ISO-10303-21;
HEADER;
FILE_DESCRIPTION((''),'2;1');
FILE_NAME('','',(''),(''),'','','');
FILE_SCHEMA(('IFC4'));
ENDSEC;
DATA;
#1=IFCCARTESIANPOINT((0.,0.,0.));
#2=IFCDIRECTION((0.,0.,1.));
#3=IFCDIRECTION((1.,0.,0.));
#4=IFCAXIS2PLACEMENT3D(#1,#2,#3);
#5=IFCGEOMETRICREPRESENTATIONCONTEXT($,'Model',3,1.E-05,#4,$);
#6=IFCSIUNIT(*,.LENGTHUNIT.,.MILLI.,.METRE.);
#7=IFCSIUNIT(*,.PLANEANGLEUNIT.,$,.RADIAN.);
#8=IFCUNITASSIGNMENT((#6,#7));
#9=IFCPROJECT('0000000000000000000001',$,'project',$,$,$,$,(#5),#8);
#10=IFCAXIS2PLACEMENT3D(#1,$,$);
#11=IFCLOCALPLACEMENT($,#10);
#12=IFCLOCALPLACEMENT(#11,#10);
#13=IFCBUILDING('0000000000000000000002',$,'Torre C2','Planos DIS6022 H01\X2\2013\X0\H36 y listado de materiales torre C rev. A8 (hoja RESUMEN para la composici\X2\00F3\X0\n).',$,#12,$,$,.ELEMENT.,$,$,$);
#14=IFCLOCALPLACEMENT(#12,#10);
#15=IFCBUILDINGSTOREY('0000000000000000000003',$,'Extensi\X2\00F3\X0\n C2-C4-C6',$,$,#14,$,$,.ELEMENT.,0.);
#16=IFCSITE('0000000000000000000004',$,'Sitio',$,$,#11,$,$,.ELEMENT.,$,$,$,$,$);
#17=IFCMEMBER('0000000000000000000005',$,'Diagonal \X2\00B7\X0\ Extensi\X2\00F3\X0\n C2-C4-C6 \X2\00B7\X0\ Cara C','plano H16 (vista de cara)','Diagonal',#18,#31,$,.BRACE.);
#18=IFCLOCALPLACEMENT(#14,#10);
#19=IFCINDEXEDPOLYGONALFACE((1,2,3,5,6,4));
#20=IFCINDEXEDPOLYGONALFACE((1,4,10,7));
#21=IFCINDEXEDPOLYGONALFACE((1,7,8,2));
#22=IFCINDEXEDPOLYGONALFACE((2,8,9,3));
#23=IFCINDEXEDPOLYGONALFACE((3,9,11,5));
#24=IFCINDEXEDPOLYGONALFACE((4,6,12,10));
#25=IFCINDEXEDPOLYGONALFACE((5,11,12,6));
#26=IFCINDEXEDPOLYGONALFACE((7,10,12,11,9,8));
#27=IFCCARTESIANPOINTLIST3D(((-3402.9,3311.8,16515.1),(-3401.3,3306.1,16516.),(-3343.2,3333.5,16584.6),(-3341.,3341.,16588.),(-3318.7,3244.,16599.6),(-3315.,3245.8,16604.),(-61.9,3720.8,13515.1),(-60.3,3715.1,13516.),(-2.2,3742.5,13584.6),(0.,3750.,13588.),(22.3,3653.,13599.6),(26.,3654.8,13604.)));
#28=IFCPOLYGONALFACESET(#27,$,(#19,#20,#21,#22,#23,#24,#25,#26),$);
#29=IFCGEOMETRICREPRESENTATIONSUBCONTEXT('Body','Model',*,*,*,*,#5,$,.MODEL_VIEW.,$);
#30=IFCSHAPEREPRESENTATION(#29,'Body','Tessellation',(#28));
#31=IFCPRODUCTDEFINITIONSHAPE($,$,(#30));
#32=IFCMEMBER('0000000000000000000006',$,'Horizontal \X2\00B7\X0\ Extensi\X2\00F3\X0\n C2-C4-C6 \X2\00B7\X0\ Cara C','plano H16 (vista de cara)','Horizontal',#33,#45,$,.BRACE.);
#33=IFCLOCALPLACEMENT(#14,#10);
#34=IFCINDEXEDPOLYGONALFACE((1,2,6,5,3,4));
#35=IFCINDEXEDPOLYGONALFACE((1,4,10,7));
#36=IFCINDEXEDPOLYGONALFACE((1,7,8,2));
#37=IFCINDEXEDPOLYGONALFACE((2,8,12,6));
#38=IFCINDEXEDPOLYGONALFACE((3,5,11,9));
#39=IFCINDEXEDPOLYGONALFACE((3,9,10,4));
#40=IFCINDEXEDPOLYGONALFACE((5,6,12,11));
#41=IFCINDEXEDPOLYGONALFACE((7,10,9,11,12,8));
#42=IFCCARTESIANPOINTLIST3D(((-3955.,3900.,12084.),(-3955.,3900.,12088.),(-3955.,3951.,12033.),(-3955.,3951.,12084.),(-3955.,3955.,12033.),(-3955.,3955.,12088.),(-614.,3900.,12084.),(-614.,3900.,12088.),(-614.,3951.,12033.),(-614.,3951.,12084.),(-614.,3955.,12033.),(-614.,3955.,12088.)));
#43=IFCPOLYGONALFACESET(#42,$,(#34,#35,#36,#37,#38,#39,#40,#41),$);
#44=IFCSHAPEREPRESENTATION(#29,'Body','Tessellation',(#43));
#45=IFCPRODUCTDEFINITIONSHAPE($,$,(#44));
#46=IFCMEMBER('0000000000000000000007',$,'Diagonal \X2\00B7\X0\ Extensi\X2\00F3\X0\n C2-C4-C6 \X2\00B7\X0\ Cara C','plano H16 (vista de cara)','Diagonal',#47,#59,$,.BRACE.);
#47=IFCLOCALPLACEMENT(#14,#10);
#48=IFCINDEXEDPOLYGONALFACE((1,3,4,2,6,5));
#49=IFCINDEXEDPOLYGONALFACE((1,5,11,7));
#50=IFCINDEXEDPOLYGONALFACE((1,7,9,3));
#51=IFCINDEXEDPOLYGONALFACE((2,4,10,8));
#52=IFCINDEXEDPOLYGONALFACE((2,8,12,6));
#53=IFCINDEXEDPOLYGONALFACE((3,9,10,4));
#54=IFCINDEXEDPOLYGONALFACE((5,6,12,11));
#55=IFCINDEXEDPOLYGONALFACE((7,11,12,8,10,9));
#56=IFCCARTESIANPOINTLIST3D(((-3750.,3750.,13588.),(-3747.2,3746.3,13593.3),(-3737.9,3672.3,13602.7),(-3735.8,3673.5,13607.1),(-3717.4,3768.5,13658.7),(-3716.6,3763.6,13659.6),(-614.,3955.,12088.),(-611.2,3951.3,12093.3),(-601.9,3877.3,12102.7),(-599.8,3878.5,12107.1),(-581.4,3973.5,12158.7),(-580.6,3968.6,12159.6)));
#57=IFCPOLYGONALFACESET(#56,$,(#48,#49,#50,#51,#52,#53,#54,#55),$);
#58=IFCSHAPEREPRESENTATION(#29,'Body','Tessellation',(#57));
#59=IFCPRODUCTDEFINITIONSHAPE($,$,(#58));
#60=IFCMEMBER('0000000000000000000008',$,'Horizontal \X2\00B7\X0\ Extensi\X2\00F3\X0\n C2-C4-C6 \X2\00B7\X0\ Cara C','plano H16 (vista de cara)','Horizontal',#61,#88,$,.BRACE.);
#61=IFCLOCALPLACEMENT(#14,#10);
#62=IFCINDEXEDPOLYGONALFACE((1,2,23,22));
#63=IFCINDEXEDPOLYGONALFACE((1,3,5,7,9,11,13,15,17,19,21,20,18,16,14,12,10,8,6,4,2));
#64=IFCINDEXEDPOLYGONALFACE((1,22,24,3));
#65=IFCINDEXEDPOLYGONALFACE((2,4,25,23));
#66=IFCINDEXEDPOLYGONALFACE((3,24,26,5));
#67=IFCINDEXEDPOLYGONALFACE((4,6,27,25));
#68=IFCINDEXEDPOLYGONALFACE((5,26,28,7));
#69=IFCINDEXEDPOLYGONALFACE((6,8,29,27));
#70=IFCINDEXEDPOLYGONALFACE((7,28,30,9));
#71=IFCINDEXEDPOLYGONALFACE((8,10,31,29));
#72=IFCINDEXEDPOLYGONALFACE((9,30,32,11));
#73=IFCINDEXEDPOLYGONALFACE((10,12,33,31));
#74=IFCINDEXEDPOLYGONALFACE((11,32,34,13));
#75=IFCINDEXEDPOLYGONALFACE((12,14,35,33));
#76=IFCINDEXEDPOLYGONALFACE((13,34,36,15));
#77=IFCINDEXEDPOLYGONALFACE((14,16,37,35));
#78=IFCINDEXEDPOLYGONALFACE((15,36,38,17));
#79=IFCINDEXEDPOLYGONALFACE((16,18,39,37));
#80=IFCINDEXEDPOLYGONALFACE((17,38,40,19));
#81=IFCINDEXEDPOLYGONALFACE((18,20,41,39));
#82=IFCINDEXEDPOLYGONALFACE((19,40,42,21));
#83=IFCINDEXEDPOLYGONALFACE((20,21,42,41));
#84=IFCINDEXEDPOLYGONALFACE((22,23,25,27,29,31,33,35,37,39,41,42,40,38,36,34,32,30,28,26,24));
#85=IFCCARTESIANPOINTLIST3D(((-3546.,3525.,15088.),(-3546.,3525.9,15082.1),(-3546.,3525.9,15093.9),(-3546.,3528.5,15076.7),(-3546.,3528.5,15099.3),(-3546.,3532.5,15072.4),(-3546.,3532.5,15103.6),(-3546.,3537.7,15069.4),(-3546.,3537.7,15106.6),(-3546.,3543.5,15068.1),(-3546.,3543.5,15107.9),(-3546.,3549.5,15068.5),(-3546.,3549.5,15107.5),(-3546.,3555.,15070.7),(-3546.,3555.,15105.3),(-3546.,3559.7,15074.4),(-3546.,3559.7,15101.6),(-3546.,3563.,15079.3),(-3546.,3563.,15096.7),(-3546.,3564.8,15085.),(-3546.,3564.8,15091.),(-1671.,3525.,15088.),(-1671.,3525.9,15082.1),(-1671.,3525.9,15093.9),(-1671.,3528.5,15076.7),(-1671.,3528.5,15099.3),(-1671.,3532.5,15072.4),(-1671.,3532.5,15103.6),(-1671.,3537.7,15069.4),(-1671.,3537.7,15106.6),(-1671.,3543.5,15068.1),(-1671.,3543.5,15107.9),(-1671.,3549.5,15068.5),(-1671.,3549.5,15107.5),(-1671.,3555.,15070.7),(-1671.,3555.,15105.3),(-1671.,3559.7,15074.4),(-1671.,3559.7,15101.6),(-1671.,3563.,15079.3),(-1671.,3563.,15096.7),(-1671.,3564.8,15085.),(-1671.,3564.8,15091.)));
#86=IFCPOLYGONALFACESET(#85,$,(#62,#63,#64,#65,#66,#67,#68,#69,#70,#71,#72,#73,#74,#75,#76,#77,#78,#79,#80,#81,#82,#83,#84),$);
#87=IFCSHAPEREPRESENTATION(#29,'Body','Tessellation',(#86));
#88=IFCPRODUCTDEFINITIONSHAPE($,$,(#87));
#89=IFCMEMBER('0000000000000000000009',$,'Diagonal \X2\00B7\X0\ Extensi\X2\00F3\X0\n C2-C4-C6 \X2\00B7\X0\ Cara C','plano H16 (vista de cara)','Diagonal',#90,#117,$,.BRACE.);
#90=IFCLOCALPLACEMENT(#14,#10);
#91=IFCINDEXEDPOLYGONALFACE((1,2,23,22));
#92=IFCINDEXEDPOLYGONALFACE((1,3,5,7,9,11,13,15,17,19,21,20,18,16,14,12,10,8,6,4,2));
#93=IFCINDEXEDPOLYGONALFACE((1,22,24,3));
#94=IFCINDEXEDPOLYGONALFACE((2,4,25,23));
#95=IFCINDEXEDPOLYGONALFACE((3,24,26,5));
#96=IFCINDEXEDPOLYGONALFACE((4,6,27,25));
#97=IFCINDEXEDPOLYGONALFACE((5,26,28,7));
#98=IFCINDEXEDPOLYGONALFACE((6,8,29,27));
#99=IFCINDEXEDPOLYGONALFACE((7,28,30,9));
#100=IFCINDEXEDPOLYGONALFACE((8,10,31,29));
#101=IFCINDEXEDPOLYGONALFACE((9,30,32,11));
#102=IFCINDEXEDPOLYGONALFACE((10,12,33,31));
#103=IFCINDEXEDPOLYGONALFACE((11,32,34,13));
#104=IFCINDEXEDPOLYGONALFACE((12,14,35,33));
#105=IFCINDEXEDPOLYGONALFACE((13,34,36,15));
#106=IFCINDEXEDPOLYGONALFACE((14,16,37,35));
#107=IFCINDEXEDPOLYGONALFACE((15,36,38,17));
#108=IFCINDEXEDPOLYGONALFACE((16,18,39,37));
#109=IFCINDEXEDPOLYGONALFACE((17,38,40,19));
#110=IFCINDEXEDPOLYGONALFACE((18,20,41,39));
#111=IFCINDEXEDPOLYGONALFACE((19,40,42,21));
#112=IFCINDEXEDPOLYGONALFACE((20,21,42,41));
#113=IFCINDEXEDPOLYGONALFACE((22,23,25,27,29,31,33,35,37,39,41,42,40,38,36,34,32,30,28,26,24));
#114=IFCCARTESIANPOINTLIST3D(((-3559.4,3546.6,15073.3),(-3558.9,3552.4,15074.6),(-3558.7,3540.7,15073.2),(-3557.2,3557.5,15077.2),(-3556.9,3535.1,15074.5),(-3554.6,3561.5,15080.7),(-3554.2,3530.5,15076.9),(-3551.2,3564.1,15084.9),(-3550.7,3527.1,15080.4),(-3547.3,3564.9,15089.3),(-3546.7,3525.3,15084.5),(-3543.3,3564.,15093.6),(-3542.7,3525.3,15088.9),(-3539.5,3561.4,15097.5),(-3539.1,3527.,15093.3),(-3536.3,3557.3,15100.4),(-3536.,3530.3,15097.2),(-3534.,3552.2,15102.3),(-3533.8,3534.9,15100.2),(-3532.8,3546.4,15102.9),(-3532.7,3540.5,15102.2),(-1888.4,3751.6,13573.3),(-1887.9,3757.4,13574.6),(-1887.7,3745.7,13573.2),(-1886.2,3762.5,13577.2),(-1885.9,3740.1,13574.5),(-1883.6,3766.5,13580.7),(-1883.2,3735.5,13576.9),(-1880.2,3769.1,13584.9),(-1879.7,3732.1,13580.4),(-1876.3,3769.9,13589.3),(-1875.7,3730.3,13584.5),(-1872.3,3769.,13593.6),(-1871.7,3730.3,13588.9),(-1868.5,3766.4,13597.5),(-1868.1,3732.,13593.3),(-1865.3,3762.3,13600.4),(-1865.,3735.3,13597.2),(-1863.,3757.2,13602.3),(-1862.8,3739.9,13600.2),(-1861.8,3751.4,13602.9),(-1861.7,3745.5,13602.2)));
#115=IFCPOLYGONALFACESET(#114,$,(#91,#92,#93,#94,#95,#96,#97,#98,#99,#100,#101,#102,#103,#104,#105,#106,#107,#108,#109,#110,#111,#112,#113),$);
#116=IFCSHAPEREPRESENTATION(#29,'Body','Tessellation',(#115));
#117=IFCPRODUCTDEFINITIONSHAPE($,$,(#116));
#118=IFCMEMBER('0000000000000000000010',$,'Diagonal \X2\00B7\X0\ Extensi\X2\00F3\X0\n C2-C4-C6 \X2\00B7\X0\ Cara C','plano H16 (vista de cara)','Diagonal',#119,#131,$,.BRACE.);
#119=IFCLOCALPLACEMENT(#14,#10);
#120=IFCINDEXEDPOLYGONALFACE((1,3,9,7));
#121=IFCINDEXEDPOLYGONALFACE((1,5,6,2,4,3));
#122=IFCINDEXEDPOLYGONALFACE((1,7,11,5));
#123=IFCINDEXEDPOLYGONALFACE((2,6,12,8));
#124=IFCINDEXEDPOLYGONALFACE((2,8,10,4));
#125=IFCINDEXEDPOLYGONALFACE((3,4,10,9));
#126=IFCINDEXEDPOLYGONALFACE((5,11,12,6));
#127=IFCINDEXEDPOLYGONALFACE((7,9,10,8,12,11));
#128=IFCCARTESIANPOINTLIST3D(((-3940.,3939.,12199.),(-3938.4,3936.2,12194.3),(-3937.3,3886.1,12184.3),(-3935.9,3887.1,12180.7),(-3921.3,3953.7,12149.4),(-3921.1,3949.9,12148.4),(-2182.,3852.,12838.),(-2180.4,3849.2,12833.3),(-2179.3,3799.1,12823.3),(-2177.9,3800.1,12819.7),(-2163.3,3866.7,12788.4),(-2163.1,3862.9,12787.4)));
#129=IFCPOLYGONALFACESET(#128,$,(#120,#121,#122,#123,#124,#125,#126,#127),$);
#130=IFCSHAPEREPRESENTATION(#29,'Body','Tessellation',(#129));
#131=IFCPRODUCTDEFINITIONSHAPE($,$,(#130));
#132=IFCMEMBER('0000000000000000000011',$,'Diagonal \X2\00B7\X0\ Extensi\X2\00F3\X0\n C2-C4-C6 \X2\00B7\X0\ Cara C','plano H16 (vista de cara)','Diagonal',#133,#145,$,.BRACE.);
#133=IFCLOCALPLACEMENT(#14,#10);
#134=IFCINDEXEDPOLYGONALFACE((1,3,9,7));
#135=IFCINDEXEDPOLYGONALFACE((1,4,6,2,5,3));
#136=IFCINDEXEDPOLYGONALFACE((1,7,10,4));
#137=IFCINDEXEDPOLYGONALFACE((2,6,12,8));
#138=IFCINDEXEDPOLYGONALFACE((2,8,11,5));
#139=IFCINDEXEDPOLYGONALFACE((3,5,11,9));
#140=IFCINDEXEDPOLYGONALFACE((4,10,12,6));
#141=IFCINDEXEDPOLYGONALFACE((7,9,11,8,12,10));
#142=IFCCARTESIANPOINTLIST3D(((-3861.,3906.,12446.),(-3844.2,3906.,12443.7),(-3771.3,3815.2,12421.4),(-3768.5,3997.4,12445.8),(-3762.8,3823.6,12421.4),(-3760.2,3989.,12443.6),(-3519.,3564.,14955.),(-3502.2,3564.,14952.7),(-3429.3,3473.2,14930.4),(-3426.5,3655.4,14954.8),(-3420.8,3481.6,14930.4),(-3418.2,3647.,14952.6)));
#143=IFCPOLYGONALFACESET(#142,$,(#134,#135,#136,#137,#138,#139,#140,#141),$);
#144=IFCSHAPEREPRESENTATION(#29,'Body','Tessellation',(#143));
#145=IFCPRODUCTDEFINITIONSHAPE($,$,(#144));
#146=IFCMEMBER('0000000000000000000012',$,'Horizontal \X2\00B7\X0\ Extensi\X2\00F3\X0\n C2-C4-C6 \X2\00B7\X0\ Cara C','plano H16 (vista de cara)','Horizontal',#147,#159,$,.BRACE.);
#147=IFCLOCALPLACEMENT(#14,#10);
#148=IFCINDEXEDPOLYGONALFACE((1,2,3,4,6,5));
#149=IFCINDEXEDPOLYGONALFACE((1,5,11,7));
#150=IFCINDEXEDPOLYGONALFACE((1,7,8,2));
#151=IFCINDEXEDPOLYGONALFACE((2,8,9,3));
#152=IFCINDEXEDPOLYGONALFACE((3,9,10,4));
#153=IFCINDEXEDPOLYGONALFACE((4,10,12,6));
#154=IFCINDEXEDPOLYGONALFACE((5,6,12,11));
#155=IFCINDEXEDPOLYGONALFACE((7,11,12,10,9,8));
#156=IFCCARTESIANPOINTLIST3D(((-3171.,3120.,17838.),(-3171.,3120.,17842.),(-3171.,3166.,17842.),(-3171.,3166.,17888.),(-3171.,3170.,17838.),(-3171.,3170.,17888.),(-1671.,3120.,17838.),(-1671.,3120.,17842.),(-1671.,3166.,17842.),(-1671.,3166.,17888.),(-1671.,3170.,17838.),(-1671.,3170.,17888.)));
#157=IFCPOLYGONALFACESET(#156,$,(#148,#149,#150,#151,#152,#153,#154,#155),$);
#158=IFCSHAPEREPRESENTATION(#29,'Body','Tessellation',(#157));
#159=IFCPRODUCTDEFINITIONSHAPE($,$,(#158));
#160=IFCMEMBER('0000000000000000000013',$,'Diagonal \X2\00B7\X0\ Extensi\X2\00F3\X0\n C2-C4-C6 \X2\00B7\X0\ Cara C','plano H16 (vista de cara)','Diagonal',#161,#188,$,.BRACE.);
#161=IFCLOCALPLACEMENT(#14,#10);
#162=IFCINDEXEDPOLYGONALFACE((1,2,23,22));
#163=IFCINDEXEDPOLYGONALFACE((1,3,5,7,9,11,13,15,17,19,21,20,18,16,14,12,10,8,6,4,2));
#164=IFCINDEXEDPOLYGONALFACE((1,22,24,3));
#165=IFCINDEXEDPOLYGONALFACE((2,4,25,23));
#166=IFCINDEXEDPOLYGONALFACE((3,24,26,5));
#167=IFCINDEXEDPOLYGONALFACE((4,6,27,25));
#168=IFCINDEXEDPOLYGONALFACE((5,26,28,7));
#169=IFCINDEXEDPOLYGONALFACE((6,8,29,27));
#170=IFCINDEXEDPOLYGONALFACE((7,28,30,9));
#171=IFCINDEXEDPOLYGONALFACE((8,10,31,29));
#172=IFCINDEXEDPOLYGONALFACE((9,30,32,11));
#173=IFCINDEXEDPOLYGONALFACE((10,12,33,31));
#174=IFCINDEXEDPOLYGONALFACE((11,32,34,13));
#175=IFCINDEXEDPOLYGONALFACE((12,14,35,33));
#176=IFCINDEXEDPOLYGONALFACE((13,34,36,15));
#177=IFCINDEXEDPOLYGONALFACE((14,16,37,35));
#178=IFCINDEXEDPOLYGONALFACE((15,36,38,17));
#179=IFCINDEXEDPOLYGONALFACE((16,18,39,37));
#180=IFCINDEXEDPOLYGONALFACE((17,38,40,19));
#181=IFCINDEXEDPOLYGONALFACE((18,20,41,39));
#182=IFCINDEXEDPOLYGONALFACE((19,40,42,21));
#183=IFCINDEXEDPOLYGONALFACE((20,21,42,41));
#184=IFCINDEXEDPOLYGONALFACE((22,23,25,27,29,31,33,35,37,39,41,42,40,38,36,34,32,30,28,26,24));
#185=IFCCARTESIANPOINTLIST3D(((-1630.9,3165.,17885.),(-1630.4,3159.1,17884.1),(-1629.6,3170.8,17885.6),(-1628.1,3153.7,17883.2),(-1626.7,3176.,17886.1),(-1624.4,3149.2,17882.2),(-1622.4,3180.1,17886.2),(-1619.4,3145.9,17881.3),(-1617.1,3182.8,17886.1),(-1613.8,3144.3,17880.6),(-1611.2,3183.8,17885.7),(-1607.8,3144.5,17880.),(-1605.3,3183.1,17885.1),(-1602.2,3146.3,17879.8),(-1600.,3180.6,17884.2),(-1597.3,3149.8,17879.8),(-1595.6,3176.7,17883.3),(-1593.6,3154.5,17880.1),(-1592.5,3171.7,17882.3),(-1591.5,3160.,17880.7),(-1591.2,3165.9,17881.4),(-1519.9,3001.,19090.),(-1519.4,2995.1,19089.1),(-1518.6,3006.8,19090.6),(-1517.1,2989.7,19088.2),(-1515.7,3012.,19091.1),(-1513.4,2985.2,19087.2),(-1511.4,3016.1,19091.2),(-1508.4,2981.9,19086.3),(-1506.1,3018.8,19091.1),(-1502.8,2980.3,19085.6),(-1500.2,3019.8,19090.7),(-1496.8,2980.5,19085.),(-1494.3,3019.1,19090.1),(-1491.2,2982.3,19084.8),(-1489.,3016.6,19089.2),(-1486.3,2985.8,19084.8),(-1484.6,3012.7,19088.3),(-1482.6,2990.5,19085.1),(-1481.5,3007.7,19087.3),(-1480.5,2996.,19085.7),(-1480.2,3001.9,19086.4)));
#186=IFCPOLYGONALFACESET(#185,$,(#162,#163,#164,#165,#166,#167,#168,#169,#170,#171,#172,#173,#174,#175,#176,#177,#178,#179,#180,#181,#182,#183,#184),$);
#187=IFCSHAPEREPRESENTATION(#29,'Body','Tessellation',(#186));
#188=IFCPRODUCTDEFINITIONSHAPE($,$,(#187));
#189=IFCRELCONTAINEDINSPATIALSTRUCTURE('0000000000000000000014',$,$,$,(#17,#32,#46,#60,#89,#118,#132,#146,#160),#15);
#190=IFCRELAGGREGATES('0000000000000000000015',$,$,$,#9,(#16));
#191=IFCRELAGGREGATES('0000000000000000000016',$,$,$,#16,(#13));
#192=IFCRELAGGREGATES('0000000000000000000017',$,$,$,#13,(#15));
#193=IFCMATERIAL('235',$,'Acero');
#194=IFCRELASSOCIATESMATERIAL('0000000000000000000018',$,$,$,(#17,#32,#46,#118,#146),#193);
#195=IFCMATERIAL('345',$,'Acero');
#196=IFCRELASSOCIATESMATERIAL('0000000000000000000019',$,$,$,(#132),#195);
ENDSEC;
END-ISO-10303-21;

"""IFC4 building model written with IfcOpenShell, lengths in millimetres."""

from ifc_helpers import new_model, si_unit, frame, frame_2d, origin, origin_with_axes, place, context, subcontext, project, spatial, circle, l_section, extrude, material, element, save


model = new_model("IFC4")

# Units and contexts
model_context = context("Model", 3, precision=1e-05, world=origin_with_axes())
body_context = subcontext(model_context, "Body", "Model", "MODEL_VIEW")
ifc_project = project(units=[si_unit("LENGTHUNIT", "METRE", prefix="MILLI"), si_unit("PLANEANGLEUNIT", "RADIAN")], contexts=[model_context])

# Site, building, storey
site_placement = place(None, origin())
site = spatial("IfcSite", under=ifc_project, at=site_placement, Name="Sitio", CompositionType="ELEMENT")
building_placement = place(site_placement, origin())
building = spatial("IfcBuilding", under=site, at=building_placement, Name="Torre C2", Description="Planos DIS6022 H01–H36 y listado de materiales torre C rev. A8 (hoja RESUMEN para la composición).", CompositionType="ELEMENT")
storey_placement = place(building_placement, origin())
storey = spatial("IfcBuildingStorey", under=building, at=storey_placement, Name="Extensión C2-C4-C6", CompositionType="ELEMENT", Elevation=0.0)

# Members
ifc_material_1 = material(Name="235", Category="Acero")
member_1_placement = place(storey_placement, frame((-3341.0, 3341.0, 16588.0), z_axis=(0.74099, 0.090711, -0.665361), x_axis=(0.260212, -0.952207, 0.159972)))
element("IfcMember", 1, at=member_1_placement, inside=storey, material=ifc_material_1, Name="Diagonal · Extensión C2-C4-C6 · Cara C", Description="plano H16 (vista de cara)", ObjectType="Diagonal", PredefinedType="BRACE", context=body_context, shape_type="SweptSolid", body=[
    extrude(l_section(Depth=100.0, Width=100.0, Thickness=6.0, at=frame_2d((50.0, 50.0))), None, (0.0, 0.0, 1.0), 4508.8),
])
member_2_placement = place(storey_placement, frame((-3955.0, 3955.0, 12088.0), z_axis=(1.0, 0.0, 0.0), x_axis=(0.0, -1.0, 0.0)))
element("IfcMember", 2, at=member_2_placement, inside=storey, material=ifc_material_1, Name="Horizontal · Extensión C2-C4-C6 · Cara C", Description="plano H16 (vista de cara)", ObjectType="Horizontal", PredefinedType="BRACE", context=body_context, shape_type="SweptSolid", body=[
    extrude(l_section(Depth=55.0, Width=55.0, Thickness=4.0, at=frame_2d((27.5, 27.5))), None, (0.0, 0.0, 1.0), 3341.0),
])
member_3_placement = place(storey_placement, frame((-614.0, 3955.0, 12088.0), z_axis=(-0.90055, -0.058869, 0.430748), x_axis=(0.151437, -0.971215, 0.183871)))
element("IfcMember", 3, at=member_3_placement, inside=storey, material=ifc_material_1, Name="Diagonal · Extensión C2-C4-C6 · Cara C", Description="plano H16 (vista de cara)", ObjectType="Diagonal", PredefinedType="BRACE", context=body_context, shape_type="SweptSolid", body=[
    extrude(l_section(Depth=80.0, Width=80.0, Thickness=5.0, at=frame_2d((40.0, 40.0))), None, (0.0, 0.0, 1.0), 3482.3),
])
member_4_placement = place(storey_placement, frame((-1671.0, 3545.0, 15088.0), z_axis=(-1.0, 0.0, 0.0), x_axis=(0.0, -1.0, 0.0)))
element("IfcMember", 4, at=member_4_placement, inside=storey, Name="Horizontal · Extensión C2-C4-C6 · Cara C", Description="plano H16 (vista de cara)", ObjectType="Horizontal", PredefinedType="BRACE", context=body_context, shape_type="SweptSolid", body=[
    extrude(circle(Radius=20.0), None, (0.0, 0.0, 1.0), 1875.0),
])
member_5_placement = place(storey_placement, frame((-3546.0, 3545.0, 15088.0), z_axis=(0.741075, 0.090916, -0.665238), x_axis=(0.347494, -0.899707, 0.264149)))
element("IfcMember", 5, at=member_5_placement, inside=storey, Name="Diagonal · Extensión C2-C4-C6 · Cara C", Description="plano H16 (vista de cara)", ObjectType="Diagonal", PredefinedType="BRACE", context=body_context, shape_type="SweptSolid", body=[
    extrude(circle(Radius=20.0), None, (0.0, 0.0, 1.0), 2254.8),
])
member_6_placement = place(storey_placement, frame((-3940.0, 3939.0, 12199.0), z_axis=(0.938825, -0.046461, 0.341245), x_axis=(0.049518, -0.962352, -0.267257)))
element("IfcMember", 6, at=member_6_placement, inside=storey, material=ifc_material_1, Name="Diagonal · Extensión C2-C4-C6 · Cara C", Description="plano H16 (vista de cara)", ObjectType="Diagonal", PredefinedType="BRACE", context=body_context, shape_type="SweptSolid", body=[
    extrude(l_section(Depth=55.0, Width=55.0, Thickness=4.0, at=frame_2d((27.5, 27.5))), None, (0.0, 0.0, 1.0), 1872.6),
])
ifc_material_2 = material(Name="345", Category="Acero")
member_7_placement = place(storey_placement, frame((-3861.0, 3906.0, 12446.0), z_axis=(0.133845, -0.133845, 0.981922), x_axis=(0.689946, -0.698675, -0.189282)))
element("IfcMember", 7, at=member_7_placement, inside=storey, material=ifc_material_2, Name="Diagonal · Extensión C2-C4-C6 · Cara C", Description="plano H16 (vista de cara)", ObjectType="Diagonal", PredefinedType="BRACE", context=body_context, shape_type="SweptSolid", body=[
    extrude(l_section(Depth=130.0, Width=130.0, Thickness=12.0, at=frame_2d((65.0, 65.0))), None, (0.0, 0.0, 1.0), 2555.2),
])
member_8_placement = place(storey_placement, frame((-1671.0, 3170.0, 17838.0), z_axis=(-1.0, 0.0, 0.0), x_axis=(0.0, -1.0, 0.0)))
element("IfcMember", 8, at=member_8_placement, inside=storey, material=ifc_material_1, Name="Horizontal · Extensión C2-C4-C6 · Cara C", Description="plano H16 (vista de cara)", ObjectType="Horizontal", PredefinedType="BRACE", context=body_context, shape_type="SweptSolid", body=[
    extrude(l_section(Depth=50.0, Width=50.0, Thickness=4.0, at=frame_2d((25.0, 25.0))), None, (0.0, 0.0, 1.0), 1500.0),
])
member_9_placement = place(storey_placement, frame((-1500.0, 3000.0, 19088.0), z_axis=(-0.090897, 0.134298, -0.986763), x_axis=(0.441701, -0.882632, -0.160814)))
element("IfcMember", 9, at=member_9_placement, inside=storey, Name="Diagonal · Extensión C2-C4-C6 · Cara C", Description="plano H16 (vista de cara)", ObjectType="Diagonal", PredefinedType="BRACE", context=body_context, shape_type="SweptSolid", body=[
    extrude(circle(Radius=20.0), None, (0.0, 0.0, 1.0), 1221.2),
])

save(model, "model.ifc")
